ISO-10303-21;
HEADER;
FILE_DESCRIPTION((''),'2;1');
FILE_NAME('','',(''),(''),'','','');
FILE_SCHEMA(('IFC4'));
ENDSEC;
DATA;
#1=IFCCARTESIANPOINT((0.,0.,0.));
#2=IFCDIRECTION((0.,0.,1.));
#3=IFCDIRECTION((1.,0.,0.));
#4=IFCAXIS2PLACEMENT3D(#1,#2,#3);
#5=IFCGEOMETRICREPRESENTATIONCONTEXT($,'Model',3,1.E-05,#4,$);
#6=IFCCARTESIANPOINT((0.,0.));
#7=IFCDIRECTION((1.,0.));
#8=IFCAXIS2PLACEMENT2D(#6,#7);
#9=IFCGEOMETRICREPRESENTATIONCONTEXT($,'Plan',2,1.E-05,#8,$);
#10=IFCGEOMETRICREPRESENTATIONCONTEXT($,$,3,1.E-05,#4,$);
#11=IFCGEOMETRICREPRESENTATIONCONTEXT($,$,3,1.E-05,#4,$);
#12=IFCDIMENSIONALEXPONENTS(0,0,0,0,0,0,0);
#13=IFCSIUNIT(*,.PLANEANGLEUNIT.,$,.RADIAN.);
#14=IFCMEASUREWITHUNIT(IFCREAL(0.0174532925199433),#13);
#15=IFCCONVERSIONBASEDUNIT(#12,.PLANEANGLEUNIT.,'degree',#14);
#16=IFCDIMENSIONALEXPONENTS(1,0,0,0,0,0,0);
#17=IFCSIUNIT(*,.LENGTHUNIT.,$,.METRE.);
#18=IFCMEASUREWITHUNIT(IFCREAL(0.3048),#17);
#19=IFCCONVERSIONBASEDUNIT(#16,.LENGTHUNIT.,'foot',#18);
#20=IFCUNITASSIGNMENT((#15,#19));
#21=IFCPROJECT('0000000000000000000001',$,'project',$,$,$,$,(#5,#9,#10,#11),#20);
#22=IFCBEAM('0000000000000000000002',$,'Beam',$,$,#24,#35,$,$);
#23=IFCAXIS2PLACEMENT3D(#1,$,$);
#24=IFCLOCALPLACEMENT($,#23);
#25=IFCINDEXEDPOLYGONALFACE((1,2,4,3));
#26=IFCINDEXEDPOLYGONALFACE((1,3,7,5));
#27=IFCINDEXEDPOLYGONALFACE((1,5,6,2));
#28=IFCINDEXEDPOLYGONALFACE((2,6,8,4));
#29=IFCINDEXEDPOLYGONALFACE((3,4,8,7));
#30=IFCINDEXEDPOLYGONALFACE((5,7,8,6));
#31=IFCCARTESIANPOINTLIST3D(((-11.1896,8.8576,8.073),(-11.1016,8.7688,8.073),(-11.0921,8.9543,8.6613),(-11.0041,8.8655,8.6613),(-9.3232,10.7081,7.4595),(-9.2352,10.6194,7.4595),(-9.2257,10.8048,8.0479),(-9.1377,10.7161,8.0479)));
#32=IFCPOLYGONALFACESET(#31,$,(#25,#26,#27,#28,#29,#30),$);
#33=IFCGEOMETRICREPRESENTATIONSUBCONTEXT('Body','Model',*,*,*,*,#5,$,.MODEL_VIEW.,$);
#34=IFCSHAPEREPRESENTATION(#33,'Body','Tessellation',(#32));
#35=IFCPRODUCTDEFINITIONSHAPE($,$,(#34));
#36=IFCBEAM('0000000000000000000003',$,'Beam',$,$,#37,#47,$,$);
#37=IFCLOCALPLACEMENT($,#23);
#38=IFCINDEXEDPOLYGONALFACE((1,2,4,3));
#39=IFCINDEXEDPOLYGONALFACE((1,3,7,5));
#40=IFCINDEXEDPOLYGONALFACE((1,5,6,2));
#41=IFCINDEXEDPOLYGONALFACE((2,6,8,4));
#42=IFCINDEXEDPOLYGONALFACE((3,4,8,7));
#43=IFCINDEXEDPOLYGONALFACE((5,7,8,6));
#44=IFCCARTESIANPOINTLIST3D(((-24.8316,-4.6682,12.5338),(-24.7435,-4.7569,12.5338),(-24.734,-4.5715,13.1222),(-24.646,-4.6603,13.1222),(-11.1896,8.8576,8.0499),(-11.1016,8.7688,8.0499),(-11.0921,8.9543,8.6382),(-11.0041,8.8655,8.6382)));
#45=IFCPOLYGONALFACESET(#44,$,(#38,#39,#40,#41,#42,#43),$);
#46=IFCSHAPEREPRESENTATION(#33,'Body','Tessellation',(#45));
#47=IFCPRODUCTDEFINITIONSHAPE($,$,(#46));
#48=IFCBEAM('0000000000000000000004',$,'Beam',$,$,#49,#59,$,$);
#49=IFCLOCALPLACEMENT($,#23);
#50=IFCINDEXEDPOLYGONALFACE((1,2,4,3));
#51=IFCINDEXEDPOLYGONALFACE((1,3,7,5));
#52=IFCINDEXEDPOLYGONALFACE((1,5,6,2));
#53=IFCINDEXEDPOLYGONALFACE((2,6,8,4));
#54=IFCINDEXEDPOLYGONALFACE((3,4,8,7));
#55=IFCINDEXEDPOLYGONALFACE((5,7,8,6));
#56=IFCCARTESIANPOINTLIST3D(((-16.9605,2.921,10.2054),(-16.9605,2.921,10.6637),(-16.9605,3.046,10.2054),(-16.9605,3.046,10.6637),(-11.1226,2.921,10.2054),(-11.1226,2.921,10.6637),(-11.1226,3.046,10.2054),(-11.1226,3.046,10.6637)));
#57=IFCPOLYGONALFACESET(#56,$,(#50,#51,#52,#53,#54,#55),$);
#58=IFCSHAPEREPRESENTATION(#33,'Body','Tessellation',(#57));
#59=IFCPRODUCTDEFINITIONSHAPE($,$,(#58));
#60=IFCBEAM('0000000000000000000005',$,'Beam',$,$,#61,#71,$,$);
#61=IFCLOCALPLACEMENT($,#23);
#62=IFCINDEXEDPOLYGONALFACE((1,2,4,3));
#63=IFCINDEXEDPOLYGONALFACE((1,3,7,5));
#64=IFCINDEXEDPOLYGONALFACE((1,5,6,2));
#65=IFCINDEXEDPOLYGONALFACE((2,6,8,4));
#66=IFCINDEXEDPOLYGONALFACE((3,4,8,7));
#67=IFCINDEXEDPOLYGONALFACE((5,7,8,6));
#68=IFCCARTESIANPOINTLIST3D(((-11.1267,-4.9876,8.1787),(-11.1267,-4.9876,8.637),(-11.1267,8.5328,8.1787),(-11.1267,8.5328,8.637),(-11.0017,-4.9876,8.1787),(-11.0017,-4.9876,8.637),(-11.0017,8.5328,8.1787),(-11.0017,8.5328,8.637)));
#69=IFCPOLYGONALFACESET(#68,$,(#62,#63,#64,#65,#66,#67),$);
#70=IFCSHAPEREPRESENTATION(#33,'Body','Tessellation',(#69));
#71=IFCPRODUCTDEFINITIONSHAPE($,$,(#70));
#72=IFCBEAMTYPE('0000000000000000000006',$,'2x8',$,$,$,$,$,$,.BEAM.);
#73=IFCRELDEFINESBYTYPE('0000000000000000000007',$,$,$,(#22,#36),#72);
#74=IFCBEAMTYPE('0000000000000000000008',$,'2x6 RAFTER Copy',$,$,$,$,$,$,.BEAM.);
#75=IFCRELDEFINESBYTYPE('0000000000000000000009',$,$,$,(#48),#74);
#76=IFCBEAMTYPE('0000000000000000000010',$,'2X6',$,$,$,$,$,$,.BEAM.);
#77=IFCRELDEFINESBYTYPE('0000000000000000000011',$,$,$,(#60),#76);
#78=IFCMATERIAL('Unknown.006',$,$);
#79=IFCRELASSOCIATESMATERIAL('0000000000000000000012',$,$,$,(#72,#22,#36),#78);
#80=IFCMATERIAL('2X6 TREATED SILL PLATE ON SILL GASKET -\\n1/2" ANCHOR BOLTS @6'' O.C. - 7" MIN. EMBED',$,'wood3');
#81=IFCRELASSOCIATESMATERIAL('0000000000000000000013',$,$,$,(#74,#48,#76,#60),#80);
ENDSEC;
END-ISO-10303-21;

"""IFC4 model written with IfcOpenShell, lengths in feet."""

from ifc_helpers import new_model, entity, si_unit, converted_unit, frame, origin_with_axes, origin_2d_with_axis, place, context, subcontext, project, rectangle, extrude, material, material_profile, profile_set, profile_usage, type_object, element, save


model = new_model("IFC4")

# Units and contexts
model_context = context("Model", 3, precision=1e-05, world=origin_with_axes())
plan_context = context("Plan", 2, precision=1e-05, world=origin_2d_with_axis())
context_of_model_1 = context(None, 3, precision=1e-05, world=origin_with_axes())
context_of_model_2 = context(None, 3, precision=1e-05, world=origin_with_axes())
body_context = subcontext(model_context, "Body", "Model", "MODEL_VIEW")
ifc_project = project(units=[converted_unit("PLANEANGLEUNIT", "degree", entity("IfcReal", 0.0174532925199433), si_unit("PLANEANGLEUNIT", "RADIAN"), dimensions=[0, 0, 0, 0, 0, 0, 0]), converted_unit("LENGTHUNIT", "foot", entity("IfcReal", 0.3048), si_unit("LENGTHUNIT", "METRE"), dimensions=[1, 0, 0, 0, 0, 0, 0])], contexts=[model_context, plan_context, context_of_model_1, context_of_model_2])

# Beams
ifc_material_1 = material(Name="Unknown.006")
ifc_material_profile_1 = material_profile(ifc_material_1, rectangle(XDim=0.125, YDim=0.6042))
ifc_profile_set_1 = profile_set([ifc_material_profile_1])
ifc_profile_usage_1 = profile_usage(ifc_profile_set_1, cardinal=5)
beam_type_1 = type_object("IfcBeamType", Name="2x8", PredefinedType="BEAM", material=ifc_profile_set_1)
beam_1_placement = place(None, frame((-11.0968, 8.8616, 8.3671), z_axis=(0.691536, 0.685648, -0.2273), x_axis=(-0.704077, 0.710123, 0.0)))
element("IfcBeam", 1, at=beam_1_placement, type_object=beam_type_1, material=ifc_profile_usage_1, Name="Beam", context=body_context, shape_type="SweptSolid", body=[
    extrude(rectangle(XDim=0.125, YDim=0.6042), origin_with_axes(), (0.0, 0.0, 1.0), 2.6989),
])
ifc_profile_usage_2 = profile_usage(ifc_profile_set_1, cardinal=5)
beam_2_placement = place(None, frame((-24.7388, -4.6642, 12.828), z_axis=(0.691536, 0.685648, -0.2273), x_axis=(-0.704077, 0.710123, 0.0)))
element("IfcBeam", 2, at=beam_2_placement, type_object=beam_type_1, material=ifc_profile_usage_2, Name="Beam", context=body_context, shape_type="SweptSolid", body=[
    extrude(rectangle(XDim=0.125, YDim=0.6042), origin_with_axes(), (0.0, 0.0, 1.0), 19.727),
])
ifc_material_2 = material(Name="2X6 TREATED SILL PLATE ON SILL GASKET -\\n1/2\" ANCHOR BOLTS @6' O.C. - 7\" MIN. EMBED", Category="wood3")
ifc_material_profile_2 = material_profile(ifc_material_2, rectangle(XDim=0.125, YDim=0.4583))
ifc_profile_set_2 = profile_set([ifc_material_profile_2])
ifc_profile_usage_3 = profile_usage(ifc_profile_set_2, cardinal=5)
beam_type_2 = type_object("IfcBeamType", Name="2x6 RAFTER Copy", PredefinedType="BEAM", material=ifc_profile_set_2)
beam_3_placement = place(None, frame((-16.9605, 2.9835, 10.4345), z_axis=(1.0, 0.0, 0.0), x_axis=(0.0, 1.0, 0.0)))
element("IfcBeam", 3, at=beam_3_placement, type_object=beam_type_2, material=ifc_profile_usage_3, Name="Beam", context=body_context, shape_type="SweptSolid", body=[
    extrude(rectangle(XDim=0.125, YDim=0.4583), origin_with_axes(), (0.0, 0.0, 1.0), 5.8379),
])
ifc_material_profile_3 = material_profile(ifc_material_2, rectangle(XDim=0.125, YDim=0.4583))
ifc_profile_set_3 = profile_set([ifc_material_profile_3])
ifc_profile_usage_4 = profile_usage(ifc_profile_set_3, cardinal=5)
beam_type_3 = type_object("IfcBeamType", Name="2X6", PredefinedType="BEAM", material=ifc_profile_set_3)
beam_4_placement = place(None, frame((-11.0642, -4.9876, 8.4079), z_axis=(0.0, 1.0, 0.0), x_axis=(-1.0, 0.0, 0.0)))
element("IfcBeam", 4, at=beam_4_placement, type_object=beam_type_3, material=ifc_profile_usage_4, Name="Beam", context=body_context, shape_type="SweptSolid", body=[
    extrude(rectangle(XDim=0.125, YDim=0.4583), origin_with_axes(), (0.0, 0.0, 1.0), 13.5204),
])

save(model, "model.ifc")
